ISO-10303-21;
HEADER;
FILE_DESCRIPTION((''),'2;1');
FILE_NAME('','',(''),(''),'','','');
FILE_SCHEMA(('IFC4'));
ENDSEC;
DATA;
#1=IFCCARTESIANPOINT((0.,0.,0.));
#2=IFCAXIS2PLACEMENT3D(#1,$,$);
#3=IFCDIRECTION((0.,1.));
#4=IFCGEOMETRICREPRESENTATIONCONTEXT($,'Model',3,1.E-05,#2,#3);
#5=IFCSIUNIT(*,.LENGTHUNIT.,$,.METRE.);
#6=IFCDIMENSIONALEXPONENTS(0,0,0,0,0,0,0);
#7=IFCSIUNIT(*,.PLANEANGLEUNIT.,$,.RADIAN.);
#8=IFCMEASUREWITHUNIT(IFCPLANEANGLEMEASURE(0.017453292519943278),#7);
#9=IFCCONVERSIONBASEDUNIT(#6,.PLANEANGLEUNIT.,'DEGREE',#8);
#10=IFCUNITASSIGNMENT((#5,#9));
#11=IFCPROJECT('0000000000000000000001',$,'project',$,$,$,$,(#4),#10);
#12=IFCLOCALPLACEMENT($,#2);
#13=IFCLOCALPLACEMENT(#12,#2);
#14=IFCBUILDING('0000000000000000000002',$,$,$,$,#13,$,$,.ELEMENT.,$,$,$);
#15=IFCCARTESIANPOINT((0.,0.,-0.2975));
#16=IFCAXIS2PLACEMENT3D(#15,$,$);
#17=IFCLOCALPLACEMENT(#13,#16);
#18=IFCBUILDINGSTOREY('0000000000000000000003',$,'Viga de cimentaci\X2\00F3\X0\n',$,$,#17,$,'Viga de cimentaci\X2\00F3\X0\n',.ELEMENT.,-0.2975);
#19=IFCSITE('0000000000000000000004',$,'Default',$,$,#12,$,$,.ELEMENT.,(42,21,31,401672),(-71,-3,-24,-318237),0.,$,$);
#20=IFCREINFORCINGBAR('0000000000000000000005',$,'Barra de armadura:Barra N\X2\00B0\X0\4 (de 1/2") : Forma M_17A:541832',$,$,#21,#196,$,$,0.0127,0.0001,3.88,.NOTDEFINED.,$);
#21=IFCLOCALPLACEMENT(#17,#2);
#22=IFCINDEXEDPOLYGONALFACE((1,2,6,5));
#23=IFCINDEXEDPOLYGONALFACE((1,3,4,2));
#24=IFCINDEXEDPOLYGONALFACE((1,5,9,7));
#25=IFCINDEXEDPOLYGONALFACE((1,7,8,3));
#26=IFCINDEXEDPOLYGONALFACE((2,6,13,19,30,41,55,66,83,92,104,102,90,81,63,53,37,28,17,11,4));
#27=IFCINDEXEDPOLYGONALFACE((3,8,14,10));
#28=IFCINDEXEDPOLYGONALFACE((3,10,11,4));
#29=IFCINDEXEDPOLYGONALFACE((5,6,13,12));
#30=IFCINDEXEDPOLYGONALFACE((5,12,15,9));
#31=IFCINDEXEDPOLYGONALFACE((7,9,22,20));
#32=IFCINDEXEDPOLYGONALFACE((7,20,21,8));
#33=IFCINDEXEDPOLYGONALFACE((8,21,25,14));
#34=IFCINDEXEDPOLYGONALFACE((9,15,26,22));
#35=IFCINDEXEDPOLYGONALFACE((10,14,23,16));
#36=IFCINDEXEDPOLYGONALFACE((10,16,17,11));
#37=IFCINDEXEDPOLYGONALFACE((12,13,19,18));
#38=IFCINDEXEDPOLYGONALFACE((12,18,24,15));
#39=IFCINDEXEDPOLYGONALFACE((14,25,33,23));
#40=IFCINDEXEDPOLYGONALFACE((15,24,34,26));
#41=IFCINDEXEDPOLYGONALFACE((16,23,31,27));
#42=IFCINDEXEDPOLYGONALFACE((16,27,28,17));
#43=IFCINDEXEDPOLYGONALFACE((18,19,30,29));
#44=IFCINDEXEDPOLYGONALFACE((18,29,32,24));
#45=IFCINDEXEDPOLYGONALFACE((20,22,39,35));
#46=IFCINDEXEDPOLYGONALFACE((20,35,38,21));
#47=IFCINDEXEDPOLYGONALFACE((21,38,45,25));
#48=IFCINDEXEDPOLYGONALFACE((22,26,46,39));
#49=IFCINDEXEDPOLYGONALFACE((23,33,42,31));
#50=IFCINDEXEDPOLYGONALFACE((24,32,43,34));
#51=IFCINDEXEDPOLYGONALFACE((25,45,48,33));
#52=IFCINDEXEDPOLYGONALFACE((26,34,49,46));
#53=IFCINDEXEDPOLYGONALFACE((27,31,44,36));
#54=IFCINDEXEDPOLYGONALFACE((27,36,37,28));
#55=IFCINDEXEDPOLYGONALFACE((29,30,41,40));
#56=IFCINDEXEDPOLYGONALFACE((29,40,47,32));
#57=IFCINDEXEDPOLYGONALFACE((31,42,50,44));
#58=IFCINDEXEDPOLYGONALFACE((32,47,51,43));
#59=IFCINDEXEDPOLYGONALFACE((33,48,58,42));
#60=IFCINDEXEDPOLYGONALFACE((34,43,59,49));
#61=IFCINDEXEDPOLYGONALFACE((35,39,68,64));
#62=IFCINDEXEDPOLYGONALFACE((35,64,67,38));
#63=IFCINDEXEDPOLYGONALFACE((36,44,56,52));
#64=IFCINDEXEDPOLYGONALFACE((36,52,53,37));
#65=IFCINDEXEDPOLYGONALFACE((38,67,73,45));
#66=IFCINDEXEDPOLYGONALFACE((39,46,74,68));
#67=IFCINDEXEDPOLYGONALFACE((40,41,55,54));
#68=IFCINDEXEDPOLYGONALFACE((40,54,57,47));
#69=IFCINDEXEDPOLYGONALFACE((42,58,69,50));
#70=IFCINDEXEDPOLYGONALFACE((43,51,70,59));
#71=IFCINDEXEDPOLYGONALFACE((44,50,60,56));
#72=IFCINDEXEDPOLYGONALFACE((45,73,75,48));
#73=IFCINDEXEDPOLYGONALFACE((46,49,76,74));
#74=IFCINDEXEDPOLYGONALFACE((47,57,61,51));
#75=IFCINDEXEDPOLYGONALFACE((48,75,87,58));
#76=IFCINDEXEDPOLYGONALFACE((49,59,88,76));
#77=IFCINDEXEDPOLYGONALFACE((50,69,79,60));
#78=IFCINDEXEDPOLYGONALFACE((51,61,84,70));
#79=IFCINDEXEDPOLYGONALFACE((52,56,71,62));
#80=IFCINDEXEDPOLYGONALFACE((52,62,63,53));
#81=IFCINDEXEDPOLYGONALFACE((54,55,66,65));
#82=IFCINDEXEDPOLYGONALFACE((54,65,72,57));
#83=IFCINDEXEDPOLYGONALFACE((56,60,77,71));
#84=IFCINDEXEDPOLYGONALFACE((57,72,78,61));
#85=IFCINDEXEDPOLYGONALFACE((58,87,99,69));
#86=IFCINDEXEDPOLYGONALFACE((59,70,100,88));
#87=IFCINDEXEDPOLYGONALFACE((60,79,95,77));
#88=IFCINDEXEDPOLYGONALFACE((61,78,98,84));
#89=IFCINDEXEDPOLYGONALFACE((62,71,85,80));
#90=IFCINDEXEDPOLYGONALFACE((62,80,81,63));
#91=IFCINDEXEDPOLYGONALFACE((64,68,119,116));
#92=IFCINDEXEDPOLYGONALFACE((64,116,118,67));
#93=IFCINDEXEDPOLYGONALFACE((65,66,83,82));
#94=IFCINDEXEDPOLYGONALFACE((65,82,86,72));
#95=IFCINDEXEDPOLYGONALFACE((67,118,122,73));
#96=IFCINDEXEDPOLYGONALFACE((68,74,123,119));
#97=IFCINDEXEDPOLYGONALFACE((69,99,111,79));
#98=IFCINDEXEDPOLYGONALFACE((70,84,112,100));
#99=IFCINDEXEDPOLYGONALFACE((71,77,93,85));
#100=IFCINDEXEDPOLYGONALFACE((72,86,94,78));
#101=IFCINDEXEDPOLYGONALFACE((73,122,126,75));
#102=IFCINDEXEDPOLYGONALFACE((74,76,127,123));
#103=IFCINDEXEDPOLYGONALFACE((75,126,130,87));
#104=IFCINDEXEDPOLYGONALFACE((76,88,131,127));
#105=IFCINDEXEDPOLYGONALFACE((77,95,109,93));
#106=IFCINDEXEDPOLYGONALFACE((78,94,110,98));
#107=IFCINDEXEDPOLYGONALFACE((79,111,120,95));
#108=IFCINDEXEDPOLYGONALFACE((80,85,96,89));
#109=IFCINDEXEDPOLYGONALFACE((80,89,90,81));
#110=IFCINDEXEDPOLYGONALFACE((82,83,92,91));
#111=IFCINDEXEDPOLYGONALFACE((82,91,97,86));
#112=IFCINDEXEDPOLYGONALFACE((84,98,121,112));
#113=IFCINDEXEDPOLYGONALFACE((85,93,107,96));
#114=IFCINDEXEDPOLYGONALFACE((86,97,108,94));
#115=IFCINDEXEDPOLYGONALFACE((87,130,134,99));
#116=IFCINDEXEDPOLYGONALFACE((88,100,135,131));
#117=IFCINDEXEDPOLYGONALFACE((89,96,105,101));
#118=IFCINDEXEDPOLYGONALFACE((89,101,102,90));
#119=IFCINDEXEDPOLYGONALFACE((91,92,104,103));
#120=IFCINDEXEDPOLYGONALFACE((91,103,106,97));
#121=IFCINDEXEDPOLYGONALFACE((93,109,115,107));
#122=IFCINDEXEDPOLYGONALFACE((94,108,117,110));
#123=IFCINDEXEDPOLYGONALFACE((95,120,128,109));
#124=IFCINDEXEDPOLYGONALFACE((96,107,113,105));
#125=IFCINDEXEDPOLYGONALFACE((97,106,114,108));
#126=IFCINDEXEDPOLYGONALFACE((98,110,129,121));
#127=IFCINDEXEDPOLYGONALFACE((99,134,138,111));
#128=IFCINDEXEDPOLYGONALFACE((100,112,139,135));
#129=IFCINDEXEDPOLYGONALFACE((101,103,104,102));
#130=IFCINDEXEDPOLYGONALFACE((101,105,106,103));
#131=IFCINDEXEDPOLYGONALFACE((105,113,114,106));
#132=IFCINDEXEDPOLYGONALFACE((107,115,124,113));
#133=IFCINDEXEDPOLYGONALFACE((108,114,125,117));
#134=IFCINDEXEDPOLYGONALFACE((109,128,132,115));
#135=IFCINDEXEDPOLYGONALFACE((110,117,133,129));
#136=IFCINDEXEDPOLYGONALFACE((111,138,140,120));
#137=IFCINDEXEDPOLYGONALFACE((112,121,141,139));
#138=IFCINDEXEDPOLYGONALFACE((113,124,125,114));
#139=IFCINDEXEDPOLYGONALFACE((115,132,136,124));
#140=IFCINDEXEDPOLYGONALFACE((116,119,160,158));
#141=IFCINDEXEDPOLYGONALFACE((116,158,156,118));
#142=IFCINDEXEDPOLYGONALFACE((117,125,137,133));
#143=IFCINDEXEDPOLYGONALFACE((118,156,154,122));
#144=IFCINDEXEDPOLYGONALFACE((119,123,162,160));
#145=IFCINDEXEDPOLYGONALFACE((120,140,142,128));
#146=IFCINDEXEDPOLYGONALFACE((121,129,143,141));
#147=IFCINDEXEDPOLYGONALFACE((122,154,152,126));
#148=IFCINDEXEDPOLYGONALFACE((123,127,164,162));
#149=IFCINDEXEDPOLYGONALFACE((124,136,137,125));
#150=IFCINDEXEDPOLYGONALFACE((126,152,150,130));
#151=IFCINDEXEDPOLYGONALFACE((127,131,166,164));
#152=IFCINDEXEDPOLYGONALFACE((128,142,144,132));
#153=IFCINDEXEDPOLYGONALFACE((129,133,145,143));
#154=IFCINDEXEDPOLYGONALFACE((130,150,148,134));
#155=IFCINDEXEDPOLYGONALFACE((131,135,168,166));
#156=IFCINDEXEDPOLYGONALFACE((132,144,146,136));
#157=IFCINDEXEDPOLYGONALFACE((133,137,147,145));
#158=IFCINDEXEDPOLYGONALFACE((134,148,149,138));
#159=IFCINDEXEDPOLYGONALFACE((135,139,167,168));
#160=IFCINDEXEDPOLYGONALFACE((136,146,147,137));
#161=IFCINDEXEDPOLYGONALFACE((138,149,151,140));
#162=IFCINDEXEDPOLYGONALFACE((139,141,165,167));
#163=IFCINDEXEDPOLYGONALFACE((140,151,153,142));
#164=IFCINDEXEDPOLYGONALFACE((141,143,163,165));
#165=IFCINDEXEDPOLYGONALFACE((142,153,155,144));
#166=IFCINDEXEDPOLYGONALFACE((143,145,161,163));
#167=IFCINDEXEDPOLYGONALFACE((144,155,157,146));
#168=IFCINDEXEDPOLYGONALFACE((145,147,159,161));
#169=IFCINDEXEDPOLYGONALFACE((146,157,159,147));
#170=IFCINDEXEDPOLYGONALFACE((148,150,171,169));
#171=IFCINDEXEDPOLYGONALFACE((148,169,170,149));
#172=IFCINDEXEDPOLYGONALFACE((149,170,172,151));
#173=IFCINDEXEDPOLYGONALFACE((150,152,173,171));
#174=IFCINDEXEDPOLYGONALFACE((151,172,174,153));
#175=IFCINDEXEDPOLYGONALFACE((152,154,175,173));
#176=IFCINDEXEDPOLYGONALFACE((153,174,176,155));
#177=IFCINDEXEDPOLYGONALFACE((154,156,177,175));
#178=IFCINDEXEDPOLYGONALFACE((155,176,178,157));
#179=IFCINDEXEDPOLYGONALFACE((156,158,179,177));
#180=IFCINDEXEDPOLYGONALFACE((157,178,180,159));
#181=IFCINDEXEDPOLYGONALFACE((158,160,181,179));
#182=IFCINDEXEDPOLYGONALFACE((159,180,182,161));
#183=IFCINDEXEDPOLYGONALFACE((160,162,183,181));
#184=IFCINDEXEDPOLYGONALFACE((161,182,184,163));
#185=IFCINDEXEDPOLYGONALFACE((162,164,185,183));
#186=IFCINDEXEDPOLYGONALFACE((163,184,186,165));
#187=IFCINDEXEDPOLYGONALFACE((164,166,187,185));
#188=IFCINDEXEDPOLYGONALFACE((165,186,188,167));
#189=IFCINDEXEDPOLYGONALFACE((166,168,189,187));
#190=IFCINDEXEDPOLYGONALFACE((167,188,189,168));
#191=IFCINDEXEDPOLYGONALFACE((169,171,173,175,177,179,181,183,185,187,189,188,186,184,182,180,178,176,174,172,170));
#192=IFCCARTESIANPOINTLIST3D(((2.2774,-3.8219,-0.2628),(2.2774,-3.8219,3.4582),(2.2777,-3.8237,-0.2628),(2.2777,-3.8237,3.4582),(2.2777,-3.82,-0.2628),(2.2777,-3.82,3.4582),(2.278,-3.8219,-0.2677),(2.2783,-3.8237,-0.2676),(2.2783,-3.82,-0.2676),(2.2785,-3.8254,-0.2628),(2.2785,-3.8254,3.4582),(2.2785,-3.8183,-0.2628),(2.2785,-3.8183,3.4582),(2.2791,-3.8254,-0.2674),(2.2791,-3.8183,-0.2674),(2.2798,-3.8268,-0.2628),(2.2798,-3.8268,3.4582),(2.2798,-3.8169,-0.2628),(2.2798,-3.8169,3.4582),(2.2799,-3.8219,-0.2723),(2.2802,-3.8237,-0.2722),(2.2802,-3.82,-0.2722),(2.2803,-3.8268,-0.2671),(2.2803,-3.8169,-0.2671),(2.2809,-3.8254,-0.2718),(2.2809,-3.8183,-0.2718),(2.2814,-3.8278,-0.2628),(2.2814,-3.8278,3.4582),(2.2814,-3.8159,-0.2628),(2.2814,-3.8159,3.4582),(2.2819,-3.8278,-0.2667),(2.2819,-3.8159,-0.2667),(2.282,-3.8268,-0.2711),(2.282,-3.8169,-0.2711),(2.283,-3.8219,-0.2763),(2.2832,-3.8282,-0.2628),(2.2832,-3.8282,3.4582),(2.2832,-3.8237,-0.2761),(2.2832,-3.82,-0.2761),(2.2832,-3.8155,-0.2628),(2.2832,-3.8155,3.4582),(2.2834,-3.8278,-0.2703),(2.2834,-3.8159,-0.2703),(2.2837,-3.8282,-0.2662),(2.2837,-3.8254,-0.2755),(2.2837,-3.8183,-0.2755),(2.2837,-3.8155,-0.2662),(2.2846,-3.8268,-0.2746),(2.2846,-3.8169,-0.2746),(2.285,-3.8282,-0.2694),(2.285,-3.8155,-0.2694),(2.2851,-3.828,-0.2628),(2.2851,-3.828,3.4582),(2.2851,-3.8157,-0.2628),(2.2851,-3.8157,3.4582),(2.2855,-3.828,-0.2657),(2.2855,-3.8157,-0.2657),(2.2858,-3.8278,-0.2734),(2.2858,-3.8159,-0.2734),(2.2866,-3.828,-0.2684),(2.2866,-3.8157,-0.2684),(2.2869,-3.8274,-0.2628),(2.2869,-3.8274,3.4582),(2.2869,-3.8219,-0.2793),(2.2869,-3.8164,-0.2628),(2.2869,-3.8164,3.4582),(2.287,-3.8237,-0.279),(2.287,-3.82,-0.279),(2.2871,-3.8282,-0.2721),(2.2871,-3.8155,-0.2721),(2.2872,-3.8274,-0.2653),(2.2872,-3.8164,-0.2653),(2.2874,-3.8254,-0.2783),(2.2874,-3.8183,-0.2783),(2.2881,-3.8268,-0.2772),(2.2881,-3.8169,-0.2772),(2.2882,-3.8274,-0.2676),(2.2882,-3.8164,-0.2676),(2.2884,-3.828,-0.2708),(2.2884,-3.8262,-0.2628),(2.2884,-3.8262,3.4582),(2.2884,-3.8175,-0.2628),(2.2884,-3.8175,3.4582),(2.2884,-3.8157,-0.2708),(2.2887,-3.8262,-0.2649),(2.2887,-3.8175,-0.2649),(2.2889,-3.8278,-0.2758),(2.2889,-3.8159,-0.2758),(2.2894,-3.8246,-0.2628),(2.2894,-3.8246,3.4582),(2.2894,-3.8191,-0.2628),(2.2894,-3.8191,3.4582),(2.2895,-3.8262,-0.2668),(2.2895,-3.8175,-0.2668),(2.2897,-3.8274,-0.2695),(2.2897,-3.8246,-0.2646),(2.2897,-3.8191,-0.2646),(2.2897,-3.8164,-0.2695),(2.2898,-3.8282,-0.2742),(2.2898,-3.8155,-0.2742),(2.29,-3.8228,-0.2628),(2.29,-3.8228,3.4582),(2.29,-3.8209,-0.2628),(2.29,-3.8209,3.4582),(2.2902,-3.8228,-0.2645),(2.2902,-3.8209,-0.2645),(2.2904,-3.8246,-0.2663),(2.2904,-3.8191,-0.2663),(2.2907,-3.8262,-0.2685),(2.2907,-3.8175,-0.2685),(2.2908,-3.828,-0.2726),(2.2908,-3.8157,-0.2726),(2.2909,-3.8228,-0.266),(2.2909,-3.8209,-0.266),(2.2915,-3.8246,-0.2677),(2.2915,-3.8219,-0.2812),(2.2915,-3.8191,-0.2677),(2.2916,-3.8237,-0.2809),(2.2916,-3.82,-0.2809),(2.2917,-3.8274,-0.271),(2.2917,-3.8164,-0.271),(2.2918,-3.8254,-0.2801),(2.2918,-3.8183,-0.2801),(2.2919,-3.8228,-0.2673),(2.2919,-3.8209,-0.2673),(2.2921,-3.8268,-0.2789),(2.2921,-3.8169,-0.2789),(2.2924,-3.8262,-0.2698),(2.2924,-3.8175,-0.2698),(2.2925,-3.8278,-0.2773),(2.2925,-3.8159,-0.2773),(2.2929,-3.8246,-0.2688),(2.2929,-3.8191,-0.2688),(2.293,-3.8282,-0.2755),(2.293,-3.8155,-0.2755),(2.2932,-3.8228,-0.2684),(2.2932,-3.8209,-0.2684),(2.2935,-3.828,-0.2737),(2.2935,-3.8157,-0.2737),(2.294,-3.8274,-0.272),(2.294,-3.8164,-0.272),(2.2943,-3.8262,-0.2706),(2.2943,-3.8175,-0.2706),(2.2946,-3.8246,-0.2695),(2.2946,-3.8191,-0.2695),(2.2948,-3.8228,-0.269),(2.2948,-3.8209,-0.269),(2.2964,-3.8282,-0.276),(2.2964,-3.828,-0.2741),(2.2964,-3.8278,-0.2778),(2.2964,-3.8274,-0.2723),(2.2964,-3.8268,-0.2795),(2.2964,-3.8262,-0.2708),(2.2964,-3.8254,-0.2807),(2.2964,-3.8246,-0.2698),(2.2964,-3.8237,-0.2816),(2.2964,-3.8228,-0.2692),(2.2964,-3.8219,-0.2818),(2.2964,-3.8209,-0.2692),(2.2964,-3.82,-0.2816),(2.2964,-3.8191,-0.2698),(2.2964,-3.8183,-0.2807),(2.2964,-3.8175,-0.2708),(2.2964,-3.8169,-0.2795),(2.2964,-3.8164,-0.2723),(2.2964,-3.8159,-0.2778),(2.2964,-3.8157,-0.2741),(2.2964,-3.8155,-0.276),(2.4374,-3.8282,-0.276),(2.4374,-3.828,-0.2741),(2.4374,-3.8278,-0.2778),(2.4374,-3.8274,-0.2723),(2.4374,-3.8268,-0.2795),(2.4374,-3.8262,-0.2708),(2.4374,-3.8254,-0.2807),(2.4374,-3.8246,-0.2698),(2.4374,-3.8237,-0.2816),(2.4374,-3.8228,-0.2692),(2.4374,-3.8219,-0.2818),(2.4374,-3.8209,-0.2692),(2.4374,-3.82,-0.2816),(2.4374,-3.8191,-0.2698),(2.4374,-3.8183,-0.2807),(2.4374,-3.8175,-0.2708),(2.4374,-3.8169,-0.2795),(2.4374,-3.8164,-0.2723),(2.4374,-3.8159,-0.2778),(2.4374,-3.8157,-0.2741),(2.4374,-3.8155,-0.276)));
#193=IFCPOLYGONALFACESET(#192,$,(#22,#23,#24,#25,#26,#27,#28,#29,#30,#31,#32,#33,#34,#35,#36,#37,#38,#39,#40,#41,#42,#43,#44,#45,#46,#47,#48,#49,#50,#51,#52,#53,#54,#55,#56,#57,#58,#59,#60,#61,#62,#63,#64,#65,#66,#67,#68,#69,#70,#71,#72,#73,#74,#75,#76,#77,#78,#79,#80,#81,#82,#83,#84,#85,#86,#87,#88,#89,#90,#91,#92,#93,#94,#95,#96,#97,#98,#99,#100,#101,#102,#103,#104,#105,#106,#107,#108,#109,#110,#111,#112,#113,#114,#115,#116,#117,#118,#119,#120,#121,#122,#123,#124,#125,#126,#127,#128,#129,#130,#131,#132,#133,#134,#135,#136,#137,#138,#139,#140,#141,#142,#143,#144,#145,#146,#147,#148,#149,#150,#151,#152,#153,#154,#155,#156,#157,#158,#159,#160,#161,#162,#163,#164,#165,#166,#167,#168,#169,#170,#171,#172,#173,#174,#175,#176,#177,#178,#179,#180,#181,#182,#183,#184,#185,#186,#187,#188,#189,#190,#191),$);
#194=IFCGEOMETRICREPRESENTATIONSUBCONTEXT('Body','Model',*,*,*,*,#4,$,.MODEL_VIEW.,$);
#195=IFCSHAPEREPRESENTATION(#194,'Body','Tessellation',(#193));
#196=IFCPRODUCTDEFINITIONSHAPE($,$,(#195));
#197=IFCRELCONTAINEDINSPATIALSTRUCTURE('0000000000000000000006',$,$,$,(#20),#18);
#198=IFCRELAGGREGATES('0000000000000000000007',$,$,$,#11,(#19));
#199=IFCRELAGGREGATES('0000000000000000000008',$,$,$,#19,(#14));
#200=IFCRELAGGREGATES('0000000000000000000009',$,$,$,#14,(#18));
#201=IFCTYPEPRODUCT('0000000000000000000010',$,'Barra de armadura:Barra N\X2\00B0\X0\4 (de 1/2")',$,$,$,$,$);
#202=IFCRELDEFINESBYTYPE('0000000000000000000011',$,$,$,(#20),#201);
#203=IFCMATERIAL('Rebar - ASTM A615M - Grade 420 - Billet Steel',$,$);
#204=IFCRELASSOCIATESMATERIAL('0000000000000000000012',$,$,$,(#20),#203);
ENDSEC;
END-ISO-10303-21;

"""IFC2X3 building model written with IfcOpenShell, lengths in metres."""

from ifc_helpers import new_model, entity, si_unit, converted_unit, direction, frame, origin, place, context, subcontext, project, spatial, material, type_object, element, save


model = new_model("IFC2X3")

# Units and contexts
model_context = context("Model", 3, precision=1e-05, world=origin(), true_north=direction((0.0, 1.0)))
body_context = subcontext(model_context, "Body", "Model", "MODEL_VIEW")
ifc_project = project(units=[si_unit("LENGTHUNIT", "METRE"), converted_unit("PLANEANGLEUNIT", "DEGREE", entity("IfcPlaneAngleMeasure", 0.017453292519943278), si_unit("PLANEANGLEUNIT", "RADIAN"), dimensions=[0, 0, 0, 0, 0, 0, 0])], contexts=[model_context])

# Site, building, storey
site_placement = place(None, origin())
site = spatial("IfcSite", under=ifc_project, at=site_placement, Name="Default", CompositionType="ELEMENT", RefLatitude=(42, 21, 31, 401672), RefLongitude=(-71, -3, -24, -318237), RefElevation=0.0)
building_placement = place(site_placement, origin())
building = spatial("IfcBuilding", under=site, at=building_placement, CompositionType="ELEMENT")
storey_placement = place(building_placement, frame((0.0, 0.0, -0.2975)))
storey = spatial("IfcBuildingStorey", under=building, at=storey_placement, Name="Viga de cimentación", LongName="Viga de cimentación", CompositionType="ELEMENT", Elevation=-0.2975)

# Reinforcing bar
ifc_material_1 = material(Name="Rebar - ASTM A615M - Grade 420 - Billet Steel")
type_product_1 = type_object("IfcTypeProduct", Name="Barra de armadura:Barra N°4 (de 1/2\")")
reinforcing_bar_1_placement = place(storey_placement, origin())
element("IfcReinforcingBar", 1, at=reinforcing_bar_1_placement, inside=storey, type_object=type_product_1, material=ifc_material_1, Name="Barra de armadura:Barra N°4 (de 1/2\") : Forma M_17A:541832", BarLength=3.88, BarRole="NOTDEFINED", CrossSectionArea=0.0001, NominalDiameter=0.0127, context=body_context, shape_type="AdvancedSweptSolid", body=[
    entity("IfcSweptDiskSolid", entity("IfcCompositeCurve", [entity("IfcCompositeCurveSegment", "CONTINUOUS", True, entity("IfcPolyline", [entity("IfcCartesianPoint", [2.2837, -3.8219, 3.4582]), entity("IfcCartesianPoint", [2.2837, -3.8219, -0.2628])])), entity("IfcCompositeCurveSegment", "CONTINUOUS", True, entity("IfcTrimmedCurve", entity("IfcCircle", entity("IfcAxis2Placement3D", entity("IfcCartesianPoint", [2.2964, -3.8219, -0.2628]), entity("IfcDirection", [0.0, -1.0, 0.0]), entity("IfcDirection", [0.0, 0.0, -1.0])), 0.0127), [entity("IfcParameterValue", 270.0)], [entity("IfcParameterValue", 360.0)], True, "PARAMETER")), entity("IfcCompositeCurveSegment", "CONTINUOUS", True, entity("IfcPolyline", [entity("IfcCartesianPoint", [2.2964, -3.8219, -0.2755]), entity("IfcCartesianPoint", [2.4374, -3.8219, -0.2755])]))], False), 0.0063, None, 0.0, 92.0),
])

save(model, "model.ifc")
